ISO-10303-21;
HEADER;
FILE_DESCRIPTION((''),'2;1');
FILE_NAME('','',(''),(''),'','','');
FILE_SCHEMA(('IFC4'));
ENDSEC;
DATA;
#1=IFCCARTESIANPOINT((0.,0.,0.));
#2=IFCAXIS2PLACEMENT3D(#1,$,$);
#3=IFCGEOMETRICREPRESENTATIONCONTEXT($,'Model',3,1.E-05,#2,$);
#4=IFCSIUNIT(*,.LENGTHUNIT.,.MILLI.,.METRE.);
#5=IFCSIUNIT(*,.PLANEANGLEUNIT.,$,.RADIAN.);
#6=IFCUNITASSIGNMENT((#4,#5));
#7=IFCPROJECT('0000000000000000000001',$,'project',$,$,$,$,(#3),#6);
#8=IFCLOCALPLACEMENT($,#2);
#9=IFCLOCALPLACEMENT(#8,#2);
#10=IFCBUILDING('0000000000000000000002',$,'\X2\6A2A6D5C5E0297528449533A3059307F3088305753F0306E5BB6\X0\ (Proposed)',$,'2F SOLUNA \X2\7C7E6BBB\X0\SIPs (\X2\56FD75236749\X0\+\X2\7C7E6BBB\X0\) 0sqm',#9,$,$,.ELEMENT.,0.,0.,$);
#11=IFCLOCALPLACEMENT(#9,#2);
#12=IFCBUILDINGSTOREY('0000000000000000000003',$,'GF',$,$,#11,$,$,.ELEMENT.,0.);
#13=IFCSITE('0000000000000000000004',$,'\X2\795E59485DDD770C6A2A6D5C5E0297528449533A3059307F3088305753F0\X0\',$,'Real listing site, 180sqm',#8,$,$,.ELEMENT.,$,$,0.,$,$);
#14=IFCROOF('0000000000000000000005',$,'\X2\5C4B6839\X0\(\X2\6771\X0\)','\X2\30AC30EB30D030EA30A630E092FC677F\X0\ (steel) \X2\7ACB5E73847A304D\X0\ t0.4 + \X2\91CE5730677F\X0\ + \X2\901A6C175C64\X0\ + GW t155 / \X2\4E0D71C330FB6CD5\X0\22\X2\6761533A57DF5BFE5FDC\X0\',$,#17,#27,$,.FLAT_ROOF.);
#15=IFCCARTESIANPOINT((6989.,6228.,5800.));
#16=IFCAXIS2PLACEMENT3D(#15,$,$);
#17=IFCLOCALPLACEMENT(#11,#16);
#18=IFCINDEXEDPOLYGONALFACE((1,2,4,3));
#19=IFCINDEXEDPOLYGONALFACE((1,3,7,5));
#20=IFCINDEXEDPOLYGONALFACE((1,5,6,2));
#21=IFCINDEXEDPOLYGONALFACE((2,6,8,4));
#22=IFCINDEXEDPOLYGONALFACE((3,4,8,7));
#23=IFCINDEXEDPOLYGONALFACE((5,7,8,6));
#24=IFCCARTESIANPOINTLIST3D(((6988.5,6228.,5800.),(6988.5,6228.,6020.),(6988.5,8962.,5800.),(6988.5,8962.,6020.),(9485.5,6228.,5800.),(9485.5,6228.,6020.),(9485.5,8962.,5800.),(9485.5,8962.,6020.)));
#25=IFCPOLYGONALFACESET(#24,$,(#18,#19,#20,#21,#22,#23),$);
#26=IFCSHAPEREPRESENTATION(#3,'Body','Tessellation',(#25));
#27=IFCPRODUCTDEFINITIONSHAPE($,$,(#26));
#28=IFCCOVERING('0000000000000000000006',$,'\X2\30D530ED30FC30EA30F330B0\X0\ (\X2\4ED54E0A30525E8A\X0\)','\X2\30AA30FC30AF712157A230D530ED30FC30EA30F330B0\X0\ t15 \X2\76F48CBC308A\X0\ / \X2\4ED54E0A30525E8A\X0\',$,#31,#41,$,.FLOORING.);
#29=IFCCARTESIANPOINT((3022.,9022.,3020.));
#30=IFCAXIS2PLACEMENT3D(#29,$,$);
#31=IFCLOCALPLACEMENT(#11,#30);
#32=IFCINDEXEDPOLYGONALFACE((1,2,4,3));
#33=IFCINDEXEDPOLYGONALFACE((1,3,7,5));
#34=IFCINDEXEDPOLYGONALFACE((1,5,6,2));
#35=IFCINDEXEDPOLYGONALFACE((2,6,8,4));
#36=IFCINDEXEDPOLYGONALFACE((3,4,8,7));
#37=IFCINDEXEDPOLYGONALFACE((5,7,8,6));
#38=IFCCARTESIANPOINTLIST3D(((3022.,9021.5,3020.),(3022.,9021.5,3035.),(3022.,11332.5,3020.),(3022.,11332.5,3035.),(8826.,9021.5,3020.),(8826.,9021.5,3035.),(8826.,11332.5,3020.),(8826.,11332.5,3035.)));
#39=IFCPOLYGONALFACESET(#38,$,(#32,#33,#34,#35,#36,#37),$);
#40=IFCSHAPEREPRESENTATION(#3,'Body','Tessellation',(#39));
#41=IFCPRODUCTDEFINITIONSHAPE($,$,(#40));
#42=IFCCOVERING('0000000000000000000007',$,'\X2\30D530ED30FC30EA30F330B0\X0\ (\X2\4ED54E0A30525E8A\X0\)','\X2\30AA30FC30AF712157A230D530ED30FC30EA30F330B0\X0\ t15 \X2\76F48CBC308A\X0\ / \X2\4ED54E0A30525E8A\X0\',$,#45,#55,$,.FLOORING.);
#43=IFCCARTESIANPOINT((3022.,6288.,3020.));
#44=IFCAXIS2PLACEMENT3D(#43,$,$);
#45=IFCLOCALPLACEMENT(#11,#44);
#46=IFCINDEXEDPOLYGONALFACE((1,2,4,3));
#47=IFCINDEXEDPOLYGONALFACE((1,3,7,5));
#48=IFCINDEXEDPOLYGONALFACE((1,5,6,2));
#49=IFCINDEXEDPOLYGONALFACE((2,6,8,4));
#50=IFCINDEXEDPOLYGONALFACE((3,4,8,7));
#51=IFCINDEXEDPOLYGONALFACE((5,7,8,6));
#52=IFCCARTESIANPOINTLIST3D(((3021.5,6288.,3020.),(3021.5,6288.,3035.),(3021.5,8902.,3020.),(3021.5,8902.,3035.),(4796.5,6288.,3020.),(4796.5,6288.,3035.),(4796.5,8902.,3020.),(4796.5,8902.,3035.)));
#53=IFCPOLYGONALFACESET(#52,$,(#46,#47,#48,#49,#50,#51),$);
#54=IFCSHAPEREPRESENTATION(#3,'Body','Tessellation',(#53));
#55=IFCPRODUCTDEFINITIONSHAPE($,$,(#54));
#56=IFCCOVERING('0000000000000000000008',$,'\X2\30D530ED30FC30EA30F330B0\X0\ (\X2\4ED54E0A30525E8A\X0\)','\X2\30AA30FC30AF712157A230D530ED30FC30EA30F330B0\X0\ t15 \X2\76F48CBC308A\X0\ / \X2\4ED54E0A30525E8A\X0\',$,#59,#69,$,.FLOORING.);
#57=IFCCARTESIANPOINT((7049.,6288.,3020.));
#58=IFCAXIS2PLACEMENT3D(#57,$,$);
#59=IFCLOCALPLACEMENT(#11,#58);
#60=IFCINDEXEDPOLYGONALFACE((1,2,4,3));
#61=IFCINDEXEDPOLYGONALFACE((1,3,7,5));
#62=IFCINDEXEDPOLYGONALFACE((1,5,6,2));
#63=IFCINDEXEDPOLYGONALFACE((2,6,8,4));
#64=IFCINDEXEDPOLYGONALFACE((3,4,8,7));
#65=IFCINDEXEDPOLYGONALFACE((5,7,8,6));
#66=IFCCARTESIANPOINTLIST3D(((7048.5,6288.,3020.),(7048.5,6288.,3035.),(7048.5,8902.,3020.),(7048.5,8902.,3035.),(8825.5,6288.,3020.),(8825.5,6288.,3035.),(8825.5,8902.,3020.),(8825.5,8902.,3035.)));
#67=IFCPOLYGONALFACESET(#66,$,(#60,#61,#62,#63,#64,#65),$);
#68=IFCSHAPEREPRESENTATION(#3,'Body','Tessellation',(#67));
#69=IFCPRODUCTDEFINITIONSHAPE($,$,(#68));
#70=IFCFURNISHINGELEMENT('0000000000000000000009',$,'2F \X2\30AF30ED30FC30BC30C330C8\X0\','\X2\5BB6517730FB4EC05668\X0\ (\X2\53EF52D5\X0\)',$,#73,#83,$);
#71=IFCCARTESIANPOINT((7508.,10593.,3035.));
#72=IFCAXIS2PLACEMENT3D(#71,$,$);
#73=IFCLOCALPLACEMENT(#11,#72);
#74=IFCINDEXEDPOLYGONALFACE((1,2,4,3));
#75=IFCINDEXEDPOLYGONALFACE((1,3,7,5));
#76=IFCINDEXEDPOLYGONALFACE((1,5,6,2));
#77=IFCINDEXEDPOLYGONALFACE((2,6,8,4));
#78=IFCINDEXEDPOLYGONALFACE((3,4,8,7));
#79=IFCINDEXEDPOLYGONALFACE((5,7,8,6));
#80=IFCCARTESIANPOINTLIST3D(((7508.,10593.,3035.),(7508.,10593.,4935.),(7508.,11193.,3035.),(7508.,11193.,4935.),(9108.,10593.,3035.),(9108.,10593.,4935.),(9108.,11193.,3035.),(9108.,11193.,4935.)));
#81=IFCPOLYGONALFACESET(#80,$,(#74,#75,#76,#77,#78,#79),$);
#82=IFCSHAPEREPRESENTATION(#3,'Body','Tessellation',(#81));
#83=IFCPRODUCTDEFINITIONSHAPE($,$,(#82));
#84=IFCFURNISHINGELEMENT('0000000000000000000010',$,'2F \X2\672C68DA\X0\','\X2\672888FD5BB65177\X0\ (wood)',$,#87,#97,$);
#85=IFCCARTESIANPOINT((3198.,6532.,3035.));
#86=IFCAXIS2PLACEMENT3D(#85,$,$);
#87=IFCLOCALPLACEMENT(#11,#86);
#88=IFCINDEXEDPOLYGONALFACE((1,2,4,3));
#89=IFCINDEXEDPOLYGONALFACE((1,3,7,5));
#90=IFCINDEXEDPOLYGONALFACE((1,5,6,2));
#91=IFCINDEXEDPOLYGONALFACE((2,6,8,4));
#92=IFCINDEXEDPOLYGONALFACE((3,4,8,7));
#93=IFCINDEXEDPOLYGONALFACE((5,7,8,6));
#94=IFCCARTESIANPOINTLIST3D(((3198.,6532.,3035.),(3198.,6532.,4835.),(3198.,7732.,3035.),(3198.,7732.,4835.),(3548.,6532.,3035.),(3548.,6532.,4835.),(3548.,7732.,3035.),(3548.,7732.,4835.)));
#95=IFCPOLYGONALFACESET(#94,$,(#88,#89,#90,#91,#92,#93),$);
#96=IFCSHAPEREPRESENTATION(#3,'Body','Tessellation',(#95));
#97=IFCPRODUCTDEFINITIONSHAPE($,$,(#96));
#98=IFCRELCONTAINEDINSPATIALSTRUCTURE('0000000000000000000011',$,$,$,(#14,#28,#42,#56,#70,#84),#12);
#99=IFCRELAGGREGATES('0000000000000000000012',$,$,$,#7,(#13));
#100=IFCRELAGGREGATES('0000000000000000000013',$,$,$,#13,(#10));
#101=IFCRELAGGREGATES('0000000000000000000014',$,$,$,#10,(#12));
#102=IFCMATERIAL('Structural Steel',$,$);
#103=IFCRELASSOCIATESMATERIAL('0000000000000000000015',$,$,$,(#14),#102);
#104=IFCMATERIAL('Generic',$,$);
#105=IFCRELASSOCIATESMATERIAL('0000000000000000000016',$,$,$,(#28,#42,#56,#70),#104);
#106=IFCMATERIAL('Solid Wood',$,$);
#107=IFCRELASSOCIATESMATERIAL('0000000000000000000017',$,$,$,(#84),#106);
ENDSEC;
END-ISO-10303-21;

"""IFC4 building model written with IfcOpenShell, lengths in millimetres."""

from ifc_helpers import new_model, si_unit, frame, frame_2d, origin, place, context, project, spatial, rectangle, extrude, material, element, save


model = new_model("IFC4")

# Units and contexts
model_context = context("Model", 3, precision=1e-05, world=origin())
ifc_project = project(units=[si_unit("LENGTHUNIT", "METRE", prefix="MILLI"), si_unit("PLANEANGLEUNIT", "RADIAN")], contexts=[model_context])

# Site, building, storey
site_placement = place(None, origin())
site = spatial("IfcSite", under=ifc_project, at=site_placement, Name="神奈川県横浜市青葉区すみよし台", ObjectType="Real listing site, 180sqm", CompositionType="ELEMENT", RefElevation=0.0)
building_placement = place(site_placement, origin())
building = spatial("IfcBuilding", under=site, at=building_placement, Name="横浜市青葉区すみよし台の家 (Proposed)", ObjectType="2F SOLUNA 籾殻SIPs (国産杉+籾殻) 0sqm", CompositionType="ELEMENT", ElevationOfRefHeight=0.0, ElevationOfTerrain=0.0)
storey_placement = place(building_placement, origin())
storey = spatial("IfcBuildingStorey", under=building, at=storey_placement, Name="GF", CompositionType="ELEMENT", Elevation=0.0)

# Shared definitions
ifc_material_1 = material(Name="Solid Wood")

# Roof
ifc_material_2 = material(Name="Structural Steel")
roof_1_placement = place(storey_placement, frame((6989.0, 6228.0, 5800.0)))
element("IfcRoof", 1, at=roof_1_placement, inside=storey, material=ifc_material_2, Name="屋根(東)", Description="ガルバリウム鋼板 (steel) 立平葺き t0.4 + 野地板 + 通気層 + GW t155 / 不燃・法22条区域対応", PredefinedType="FLAT_ROOF", context=model_context, shape_type="SweptSolid", body=[
    extrude(rectangle(XDim=2497.0, YDim=2734.0, at=frame_2d((1248.0, 1367.0))), frame((6989.0, 6228.0, 5800.0)), (0.0, 0.0, 1.0), 220.0),
])

# Coverings
ifc_material_3 = material(Name="Generic")
covering_1_placement = place(storey_placement, frame((3022.0, 9022.0, 3020.0)))
element("IfcCovering", 2, at=covering_1_placement, inside=storey, material=ifc_material_3, Name="フローリング (仕上げ床)", Description="オーク無垢フローリング t15 直貼り / 仕上げ床", PredefinedType="FLOORING", context=model_context, shape_type="SweptSolid", body=[
    extrude(rectangle(XDim=5804.0, YDim=2311.0, at=frame_2d((2902.0, 1155.0))), frame((3022.0, 9022.0, 3020.0)), (0.0, 0.0, 1.0), 15.0),
])
covering_2_placement = place(storey_placement, frame((3022.0, 6288.0, 3020.0)))
element("IfcCovering", 3, at=covering_2_placement, inside=storey, material=ifc_material_3, Name="フローリング (仕上げ床)", Description="オーク無垢フローリング t15 直貼り / 仕上げ床", PredefinedType="FLOORING", context=model_context, shape_type="SweptSolid", body=[
    extrude(rectangle(XDim=1775.0, YDim=2614.0, at=frame_2d((887.0, 1307.0))), frame((3022.0, 6288.0, 3020.0)), (0.0, 0.0, 1.0), 15.0),
])
covering_3_placement = place(storey_placement, frame((7049.0, 6288.0, 3020.0)))
element("IfcCovering", 4, at=covering_3_placement, inside=storey, material=ifc_material_3, Name="フローリング (仕上げ床)", Description="オーク無垢フローリング t15 直貼り / 仕上げ床", PredefinedType="FLOORING", context=model_context, shape_type="SweptSolid", body=[
    extrude(rectangle(XDim=1777.0, YDim=2614.0, at=frame_2d((888.0, 1307.0))), frame((7049.0, 6288.0, 3020.0)), (0.0, 0.0, 1.0), 15.0),
])

# Furnishing elements
furnishing_1_placement = place(storey_placement, frame((7508.0, 10593.0, 3035.0)))
element("IfcFurnishingElement", 5, at=furnishing_1_placement, inside=storey, material=ifc_material_3, Name="2F クローゼット", Description="家具・什器 (可動)", context=model_context, shape_type="SweptSolid", body=[
    extrude(rectangle(XDim=1600.0, YDim=600.0, at=frame_2d((800.0, 300.0))), frame((7508.0, 10593.0, 3035.0)), (0.0, 0.0, 1.0), 1900.0),
])
furnishing_2_placement = place(storey_placement, frame((3198.0, 6532.0, 3035.0)))
element("IfcFurnishingElement", 6, at=furnishing_2_placement, inside=storey, material=ifc_material_1, Name="2F 本棚", Description="木製家具 (wood)", context=model_context, shape_type="SweptSolid", body=[
    extrude(rectangle(XDim=350.0, YDim=1200.0, at=frame_2d((175.0, 600.0))), frame((3198.0, 6532.0, 3035.0)), (0.0, 0.0, 1.0), 1800.0),
])

save(model, "model.ifc")
